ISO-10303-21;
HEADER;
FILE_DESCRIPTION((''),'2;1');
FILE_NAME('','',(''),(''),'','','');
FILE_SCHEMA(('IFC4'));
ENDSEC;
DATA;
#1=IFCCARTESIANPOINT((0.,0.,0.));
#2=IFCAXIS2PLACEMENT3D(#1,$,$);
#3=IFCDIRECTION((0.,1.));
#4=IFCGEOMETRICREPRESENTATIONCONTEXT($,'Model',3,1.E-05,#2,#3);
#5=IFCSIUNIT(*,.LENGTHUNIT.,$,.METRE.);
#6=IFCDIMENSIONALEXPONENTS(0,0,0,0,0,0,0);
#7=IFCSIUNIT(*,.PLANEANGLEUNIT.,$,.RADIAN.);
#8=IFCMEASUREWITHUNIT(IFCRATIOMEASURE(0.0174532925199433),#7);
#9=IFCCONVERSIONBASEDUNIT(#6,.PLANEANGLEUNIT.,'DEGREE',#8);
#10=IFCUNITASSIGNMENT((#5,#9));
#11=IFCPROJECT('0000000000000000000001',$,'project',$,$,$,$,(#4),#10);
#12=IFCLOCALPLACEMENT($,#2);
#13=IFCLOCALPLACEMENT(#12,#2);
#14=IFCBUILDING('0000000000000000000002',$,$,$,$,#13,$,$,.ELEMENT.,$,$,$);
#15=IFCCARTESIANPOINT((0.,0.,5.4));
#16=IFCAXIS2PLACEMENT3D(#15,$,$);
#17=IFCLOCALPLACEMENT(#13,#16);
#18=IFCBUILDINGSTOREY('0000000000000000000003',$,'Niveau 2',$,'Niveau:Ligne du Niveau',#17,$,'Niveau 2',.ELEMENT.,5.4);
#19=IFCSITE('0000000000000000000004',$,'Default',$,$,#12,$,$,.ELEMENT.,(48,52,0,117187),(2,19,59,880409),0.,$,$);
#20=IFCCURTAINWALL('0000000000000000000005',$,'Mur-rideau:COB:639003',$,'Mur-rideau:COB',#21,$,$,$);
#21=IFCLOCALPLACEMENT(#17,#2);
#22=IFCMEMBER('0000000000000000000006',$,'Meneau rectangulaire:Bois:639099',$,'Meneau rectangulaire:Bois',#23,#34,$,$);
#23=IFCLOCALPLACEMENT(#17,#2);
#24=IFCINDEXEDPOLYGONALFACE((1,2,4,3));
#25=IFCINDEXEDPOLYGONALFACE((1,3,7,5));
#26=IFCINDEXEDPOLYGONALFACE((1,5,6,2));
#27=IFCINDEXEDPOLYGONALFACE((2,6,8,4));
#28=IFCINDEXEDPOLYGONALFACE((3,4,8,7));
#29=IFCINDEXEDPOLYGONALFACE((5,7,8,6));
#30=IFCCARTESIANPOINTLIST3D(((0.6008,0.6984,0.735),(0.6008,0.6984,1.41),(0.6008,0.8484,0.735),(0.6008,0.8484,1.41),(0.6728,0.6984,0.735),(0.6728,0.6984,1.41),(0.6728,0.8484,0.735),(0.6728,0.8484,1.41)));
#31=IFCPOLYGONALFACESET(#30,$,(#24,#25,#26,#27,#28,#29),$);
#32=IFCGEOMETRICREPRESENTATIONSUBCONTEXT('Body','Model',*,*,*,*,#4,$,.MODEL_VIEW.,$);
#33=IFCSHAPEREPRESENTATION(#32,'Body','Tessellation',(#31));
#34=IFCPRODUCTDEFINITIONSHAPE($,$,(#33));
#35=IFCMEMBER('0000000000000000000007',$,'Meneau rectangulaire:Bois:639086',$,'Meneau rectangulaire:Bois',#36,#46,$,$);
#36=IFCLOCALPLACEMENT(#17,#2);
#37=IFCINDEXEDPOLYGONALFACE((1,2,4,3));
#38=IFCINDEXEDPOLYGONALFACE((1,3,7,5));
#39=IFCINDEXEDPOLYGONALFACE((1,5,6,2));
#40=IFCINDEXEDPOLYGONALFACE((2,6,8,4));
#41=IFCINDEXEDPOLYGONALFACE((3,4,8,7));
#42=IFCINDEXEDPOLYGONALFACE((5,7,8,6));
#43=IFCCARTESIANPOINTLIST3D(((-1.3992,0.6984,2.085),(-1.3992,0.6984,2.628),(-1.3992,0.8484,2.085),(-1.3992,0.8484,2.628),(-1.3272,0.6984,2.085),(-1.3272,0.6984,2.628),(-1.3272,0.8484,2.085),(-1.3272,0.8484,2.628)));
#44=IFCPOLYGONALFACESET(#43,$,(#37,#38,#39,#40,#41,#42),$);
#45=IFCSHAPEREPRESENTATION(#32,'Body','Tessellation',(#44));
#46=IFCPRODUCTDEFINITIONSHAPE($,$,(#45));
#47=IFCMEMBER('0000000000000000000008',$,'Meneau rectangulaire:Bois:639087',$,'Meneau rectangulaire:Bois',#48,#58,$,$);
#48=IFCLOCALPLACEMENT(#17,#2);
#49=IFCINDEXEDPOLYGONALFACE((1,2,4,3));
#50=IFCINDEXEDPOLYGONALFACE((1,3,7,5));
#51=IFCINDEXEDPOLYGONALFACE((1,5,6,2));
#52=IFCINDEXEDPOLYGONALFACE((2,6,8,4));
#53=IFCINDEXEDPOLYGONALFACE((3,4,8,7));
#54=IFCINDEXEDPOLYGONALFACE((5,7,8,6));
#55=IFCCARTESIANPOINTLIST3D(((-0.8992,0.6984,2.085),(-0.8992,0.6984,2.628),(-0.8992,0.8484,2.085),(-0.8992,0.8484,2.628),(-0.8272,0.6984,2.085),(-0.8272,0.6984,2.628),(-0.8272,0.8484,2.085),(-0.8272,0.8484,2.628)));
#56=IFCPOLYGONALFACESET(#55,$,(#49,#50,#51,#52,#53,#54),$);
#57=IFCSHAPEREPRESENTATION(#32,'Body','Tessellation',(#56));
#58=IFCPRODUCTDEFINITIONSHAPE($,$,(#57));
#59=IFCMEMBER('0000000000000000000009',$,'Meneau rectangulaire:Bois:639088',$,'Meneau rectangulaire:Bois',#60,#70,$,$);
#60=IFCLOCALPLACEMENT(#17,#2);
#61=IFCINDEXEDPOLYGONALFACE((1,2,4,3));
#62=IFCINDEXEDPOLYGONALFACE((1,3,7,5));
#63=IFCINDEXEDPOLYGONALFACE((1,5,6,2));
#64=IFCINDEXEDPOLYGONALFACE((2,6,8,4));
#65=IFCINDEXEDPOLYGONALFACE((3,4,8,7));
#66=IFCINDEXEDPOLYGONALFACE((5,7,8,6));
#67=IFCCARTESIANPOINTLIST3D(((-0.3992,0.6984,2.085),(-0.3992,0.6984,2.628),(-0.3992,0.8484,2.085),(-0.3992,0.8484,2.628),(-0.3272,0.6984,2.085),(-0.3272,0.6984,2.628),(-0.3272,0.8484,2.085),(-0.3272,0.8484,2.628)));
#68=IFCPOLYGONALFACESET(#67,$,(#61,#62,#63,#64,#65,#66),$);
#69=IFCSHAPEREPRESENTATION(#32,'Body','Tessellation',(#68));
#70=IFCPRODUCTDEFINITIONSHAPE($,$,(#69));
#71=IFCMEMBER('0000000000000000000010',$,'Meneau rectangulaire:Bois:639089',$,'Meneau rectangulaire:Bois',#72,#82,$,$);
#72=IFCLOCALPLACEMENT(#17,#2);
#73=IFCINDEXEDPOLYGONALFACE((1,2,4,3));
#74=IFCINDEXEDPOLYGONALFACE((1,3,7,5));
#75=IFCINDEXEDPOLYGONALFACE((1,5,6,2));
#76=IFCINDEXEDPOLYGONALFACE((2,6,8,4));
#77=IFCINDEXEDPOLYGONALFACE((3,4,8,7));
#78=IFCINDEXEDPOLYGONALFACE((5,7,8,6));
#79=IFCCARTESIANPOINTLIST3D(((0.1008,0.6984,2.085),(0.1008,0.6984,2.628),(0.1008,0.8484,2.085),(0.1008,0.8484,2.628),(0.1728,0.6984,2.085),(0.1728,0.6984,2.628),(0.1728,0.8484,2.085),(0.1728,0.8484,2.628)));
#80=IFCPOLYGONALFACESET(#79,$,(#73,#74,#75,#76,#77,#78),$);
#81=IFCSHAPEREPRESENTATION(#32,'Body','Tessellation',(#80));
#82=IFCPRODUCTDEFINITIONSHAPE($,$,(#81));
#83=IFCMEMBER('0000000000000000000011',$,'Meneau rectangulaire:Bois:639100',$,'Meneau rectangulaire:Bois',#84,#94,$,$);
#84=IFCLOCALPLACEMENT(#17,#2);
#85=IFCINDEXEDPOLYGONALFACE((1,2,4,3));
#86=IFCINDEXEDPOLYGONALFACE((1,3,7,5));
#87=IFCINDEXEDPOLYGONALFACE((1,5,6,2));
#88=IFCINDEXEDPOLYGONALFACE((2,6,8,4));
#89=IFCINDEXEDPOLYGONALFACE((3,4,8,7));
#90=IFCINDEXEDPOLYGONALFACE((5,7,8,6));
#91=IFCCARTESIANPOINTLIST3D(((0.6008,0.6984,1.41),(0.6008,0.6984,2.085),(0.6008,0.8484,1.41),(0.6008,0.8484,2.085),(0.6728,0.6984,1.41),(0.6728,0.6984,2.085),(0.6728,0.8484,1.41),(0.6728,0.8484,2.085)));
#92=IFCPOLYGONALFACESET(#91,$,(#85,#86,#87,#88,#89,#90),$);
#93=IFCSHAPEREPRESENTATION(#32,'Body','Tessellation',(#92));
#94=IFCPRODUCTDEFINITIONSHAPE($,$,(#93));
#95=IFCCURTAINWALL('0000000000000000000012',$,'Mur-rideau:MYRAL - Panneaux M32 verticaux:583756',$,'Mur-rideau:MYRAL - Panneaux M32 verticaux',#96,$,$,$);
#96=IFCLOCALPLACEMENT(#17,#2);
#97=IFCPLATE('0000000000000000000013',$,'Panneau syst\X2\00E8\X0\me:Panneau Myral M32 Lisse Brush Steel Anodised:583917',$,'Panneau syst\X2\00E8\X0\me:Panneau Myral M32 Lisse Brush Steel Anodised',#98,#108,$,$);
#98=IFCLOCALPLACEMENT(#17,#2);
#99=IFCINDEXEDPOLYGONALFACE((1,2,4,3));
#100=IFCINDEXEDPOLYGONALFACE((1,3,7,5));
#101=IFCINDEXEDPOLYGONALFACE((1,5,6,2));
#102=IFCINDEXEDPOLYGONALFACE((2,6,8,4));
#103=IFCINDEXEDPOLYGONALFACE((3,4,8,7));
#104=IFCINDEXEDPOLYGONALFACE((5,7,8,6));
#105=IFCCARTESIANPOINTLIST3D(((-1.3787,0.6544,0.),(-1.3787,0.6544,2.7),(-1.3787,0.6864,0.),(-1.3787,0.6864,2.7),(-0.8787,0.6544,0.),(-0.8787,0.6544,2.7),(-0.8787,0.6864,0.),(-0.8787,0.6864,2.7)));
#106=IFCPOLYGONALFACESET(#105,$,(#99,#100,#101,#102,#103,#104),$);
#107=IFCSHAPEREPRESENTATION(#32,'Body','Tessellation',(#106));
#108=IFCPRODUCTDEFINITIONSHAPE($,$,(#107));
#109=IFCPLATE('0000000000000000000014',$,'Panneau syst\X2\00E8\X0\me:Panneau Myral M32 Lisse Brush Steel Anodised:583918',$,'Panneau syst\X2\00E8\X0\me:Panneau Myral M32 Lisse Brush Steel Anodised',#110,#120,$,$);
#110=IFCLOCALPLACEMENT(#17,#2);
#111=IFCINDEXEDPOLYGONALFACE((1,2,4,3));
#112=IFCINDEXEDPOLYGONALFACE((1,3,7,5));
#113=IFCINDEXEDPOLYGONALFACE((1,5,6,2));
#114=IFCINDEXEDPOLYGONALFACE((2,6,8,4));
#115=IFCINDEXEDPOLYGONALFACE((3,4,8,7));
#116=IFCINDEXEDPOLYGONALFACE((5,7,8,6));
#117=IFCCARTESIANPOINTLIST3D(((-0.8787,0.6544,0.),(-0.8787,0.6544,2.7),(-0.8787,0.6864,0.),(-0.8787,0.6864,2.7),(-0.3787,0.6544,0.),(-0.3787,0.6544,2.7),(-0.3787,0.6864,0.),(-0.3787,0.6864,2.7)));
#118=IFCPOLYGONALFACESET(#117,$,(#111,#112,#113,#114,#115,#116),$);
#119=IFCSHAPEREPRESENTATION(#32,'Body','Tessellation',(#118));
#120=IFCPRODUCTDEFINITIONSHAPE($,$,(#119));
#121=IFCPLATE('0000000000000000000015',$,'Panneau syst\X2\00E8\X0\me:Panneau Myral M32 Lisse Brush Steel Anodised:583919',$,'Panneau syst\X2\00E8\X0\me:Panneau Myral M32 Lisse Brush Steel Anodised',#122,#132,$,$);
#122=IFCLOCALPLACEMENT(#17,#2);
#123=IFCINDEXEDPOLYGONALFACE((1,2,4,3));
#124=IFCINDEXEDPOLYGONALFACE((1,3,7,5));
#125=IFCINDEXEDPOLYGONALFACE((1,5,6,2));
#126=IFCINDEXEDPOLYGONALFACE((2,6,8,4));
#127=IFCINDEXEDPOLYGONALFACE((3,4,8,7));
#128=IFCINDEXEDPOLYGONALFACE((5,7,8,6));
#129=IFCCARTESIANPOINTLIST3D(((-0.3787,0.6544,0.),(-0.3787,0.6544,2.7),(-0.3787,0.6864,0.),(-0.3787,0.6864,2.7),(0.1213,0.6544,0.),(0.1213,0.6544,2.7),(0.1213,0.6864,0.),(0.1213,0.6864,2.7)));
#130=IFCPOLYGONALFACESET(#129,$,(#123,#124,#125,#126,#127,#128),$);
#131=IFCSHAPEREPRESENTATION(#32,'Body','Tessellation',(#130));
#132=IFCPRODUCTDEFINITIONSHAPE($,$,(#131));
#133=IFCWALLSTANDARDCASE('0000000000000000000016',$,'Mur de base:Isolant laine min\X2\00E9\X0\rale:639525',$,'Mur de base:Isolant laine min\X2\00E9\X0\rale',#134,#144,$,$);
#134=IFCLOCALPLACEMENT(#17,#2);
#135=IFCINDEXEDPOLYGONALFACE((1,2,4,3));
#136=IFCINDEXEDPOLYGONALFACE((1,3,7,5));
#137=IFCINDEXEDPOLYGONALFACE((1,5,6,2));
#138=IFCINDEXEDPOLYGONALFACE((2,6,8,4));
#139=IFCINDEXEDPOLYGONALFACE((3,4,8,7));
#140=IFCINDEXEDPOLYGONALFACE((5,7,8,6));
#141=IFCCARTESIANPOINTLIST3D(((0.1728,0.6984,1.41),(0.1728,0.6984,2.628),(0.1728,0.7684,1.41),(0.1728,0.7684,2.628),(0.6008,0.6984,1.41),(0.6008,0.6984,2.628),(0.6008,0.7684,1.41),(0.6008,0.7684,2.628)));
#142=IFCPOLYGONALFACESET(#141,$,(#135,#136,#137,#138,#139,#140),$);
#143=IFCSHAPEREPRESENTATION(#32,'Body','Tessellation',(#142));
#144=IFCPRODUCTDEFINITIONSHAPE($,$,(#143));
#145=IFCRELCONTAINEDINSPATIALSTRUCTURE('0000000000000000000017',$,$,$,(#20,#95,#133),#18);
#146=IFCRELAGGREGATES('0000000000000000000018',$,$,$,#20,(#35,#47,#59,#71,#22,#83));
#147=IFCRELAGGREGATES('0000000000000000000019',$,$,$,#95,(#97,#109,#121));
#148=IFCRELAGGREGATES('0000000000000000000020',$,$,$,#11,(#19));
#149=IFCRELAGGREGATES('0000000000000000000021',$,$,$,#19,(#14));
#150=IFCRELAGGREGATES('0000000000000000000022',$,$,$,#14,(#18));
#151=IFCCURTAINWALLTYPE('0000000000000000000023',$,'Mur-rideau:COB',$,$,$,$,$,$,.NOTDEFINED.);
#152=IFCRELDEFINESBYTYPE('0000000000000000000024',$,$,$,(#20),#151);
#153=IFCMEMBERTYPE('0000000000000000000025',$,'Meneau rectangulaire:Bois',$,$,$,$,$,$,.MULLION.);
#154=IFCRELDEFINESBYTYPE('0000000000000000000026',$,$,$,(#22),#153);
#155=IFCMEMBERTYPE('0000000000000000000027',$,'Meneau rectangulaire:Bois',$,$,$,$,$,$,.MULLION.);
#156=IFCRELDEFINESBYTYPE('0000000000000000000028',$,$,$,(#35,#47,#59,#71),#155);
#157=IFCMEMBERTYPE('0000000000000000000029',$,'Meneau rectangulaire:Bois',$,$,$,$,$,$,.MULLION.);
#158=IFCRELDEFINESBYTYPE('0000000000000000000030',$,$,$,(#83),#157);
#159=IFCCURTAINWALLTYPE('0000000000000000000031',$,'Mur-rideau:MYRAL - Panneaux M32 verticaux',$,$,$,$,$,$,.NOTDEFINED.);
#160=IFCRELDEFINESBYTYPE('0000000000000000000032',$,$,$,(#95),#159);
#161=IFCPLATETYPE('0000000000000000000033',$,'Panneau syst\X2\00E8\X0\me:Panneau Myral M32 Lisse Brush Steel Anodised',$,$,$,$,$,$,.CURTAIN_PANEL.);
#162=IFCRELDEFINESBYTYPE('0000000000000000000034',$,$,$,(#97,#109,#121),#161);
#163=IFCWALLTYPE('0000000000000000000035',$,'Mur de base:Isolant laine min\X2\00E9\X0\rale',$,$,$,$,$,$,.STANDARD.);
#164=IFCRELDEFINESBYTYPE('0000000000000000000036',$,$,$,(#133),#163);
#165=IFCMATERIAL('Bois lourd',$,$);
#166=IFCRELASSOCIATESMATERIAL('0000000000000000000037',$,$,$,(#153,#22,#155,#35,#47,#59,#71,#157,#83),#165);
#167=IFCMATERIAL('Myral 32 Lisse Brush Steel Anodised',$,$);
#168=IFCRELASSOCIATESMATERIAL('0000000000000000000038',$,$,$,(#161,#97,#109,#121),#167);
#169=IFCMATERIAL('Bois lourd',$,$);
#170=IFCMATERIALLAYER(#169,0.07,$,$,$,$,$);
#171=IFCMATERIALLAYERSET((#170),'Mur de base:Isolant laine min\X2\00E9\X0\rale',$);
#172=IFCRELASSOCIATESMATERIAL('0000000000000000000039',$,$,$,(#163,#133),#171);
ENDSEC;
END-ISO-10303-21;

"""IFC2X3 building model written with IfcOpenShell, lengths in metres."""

from ifc_helpers import new_model, entity, si_unit, converted_unit, direction, frame, frame_2d, origin, origin_2d_with_axis, place, context, subcontext, project, spatial, rectangle, extrude, source, transform, mapped, material, layer, layer_set, layer_usage, type_object, type_shapes, element, aggregate, save


model = new_model("IFC2X3")

# Units and contexts
model_context = context("Model", 3, precision=1e-05, world=origin(), true_north=direction((0.0, 1.0)))
body_context = subcontext(model_context, "Body", "Model", "MODEL_VIEW")
ifc_project = project(units=[si_unit("LENGTHUNIT", "METRE"), converted_unit("PLANEANGLEUNIT", "DEGREE", entity("IfcRatioMeasure", 0.0174532925199433), si_unit("PLANEANGLEUNIT", "RADIAN"), dimensions=[0, 0, 0, 0, 0, 0, 0])], contexts=[model_context])

# Site, building, storey
site_placement = place(None, origin())
site = spatial("IfcSite", under=ifc_project, at=site_placement, Name="Default", CompositionType="ELEMENT", RefLatitude=(48, 52, 0, 117187), RefLongitude=(2, 19, 59, 880409), RefElevation=0.0)
building_placement = place(site_placement, origin())
building = spatial("IfcBuilding", under=site, at=building_placement, CompositionType="ELEMENT")
storey_placement = place(building_placement, frame((0.0, 0.0, 5.4)))
storey = spatial("IfcBuildingStorey", under=building, at=storey_placement, Name="Niveau 2", ObjectType="Niveau:Ligne du Niveau", LongName="Niveau 2", CompositionType="ELEMENT", Elevation=5.4)

# Curtain wall, members
curtain_wall_type_1 = type_object("IfcCurtainWallType", Name="Mur-rideau:COB", PredefinedType="NOTDEFINED")
curtain_wall_1_placement = place(storey_placement, frame((0.0, 0.0, -5.4)))
curtain_wall_1 = element("IfcCurtainWall", 1, at=curtain_wall_1_placement, inside=storey, type_object=curtain_wall_type_1, Name="Mur-rideau:COB:639003", ObjectType="Mur-rideau:COB")
ifc_material_1 = material(Name="Bois lourd")
member_type_1 = type_object("IfcMemberType", Name="Meneau rectangulaire:Bois", PredefinedType="MULLION", material=ifc_material_1)
shared_shape_1 = source(origin(), body_context, "Body", "SweptSolid", [
    extrude(rectangle(XDim=0.15, YDim=0.072, at=origin_2d_with_axis()), frame((-0.024, 0.0, -0.675), z_axis=(0.0, 0.0, 1.0), x_axis=(0.0, -1.0, 0.0)), (0.0, 0.0, 1.0), 0.675),
])
type_shapes(member_type_1, [shared_shape_1])
member_1_placement = place(storey_placement, frame((0.6608, 0.7734, 0.735), z_axis=(0.0, 0.0, -1.0), x_axis=(1.0, 0.0, 0.0)))
member_1 = element("IfcMember", 2, at=member_1_placement, type_object=member_type_1, material=ifc_material_1, Name="Meneau rectangulaire:Bois:639099", ObjectType="Meneau rectangulaire:Bois", context=body_context, shape_type="MappedRepresentation", body=[
    mapped(shared_shape_1, transform((0.0, 0.0, 0.0), scale=1.0)),
])
member_type_2 = type_object("IfcMemberType", Name="Meneau rectangulaire:Bois", PredefinedType="MULLION", material=ifc_material_1)
shared_shape_2 = source(origin(), body_context, "Body", "SweptSolid", [
    extrude(rectangle(XDim=0.15, YDim=0.072, at=origin_2d_with_axis()), frame((-0.024, 0.0, -0.543), z_axis=(0.0, 0.0, 1.0), x_axis=(0.0, -1.0, 0.0)), (0.0, 0.0, 1.0), 0.543),
])
type_shapes(member_type_2, [shared_shape_2])
member_2_placement = place(storey_placement, frame((-1.3392, 0.7734, 2.085), z_axis=(0.0, 0.0, -1.0), x_axis=(1.0, 0.0, 0.0)))
member_2 = element("IfcMember", 3, at=member_2_placement, type_object=member_type_2, material=ifc_material_1, Name="Meneau rectangulaire:Bois:639086", ObjectType="Meneau rectangulaire:Bois", context=body_context, shape_type="MappedRepresentation", body=[
    mapped(shared_shape_2, transform((0.0, 0.0, 0.0), scale=1.0)),
])
member_3_placement = place(storey_placement, frame((-0.8392, 0.7734, 2.085), z_axis=(0.0, 0.0, -1.0), x_axis=(1.0, 0.0, 0.0)))
member_3 = element("IfcMember", 4, at=member_3_placement, type_object=member_type_2, material=ifc_material_1, Name="Meneau rectangulaire:Bois:639087", ObjectType="Meneau rectangulaire:Bois", context=body_context, shape_type="MappedRepresentation", body=[
    mapped(shared_shape_2, transform((0.0, 0.0, 0.0), scale=1.0)),
])
member_4_placement = place(storey_placement, frame((-0.3392, 0.7734, 2.085), z_axis=(0.0, 0.0, -1.0), x_axis=(1.0, 0.0, 0.0)))
member_4 = element("IfcMember", 5, at=member_4_placement, type_object=member_type_2, material=ifc_material_1, Name="Meneau rectangulaire:Bois:639088", ObjectType="Meneau rectangulaire:Bois", context=body_context, shape_type="MappedRepresentation", body=[
    mapped(shared_shape_2, transform((0.0, 0.0, 0.0), scale=1.0)),
])
member_5_placement = place(storey_placement, frame((0.1608, 0.7734, 2.085), z_axis=(0.0, 0.0, -1.0), x_axis=(1.0, 0.0, 0.0)))
member_5 = element("IfcMember", 6, at=member_5_placement, type_object=member_type_2, material=ifc_material_1, Name="Meneau rectangulaire:Bois:639089", ObjectType="Meneau rectangulaire:Bois", context=body_context, shape_type="MappedRepresentation", body=[
    mapped(shared_shape_2, transform((0.0, 0.0, 0.0), scale=1.0)),
])
member_type_3 = type_object("IfcMemberType", Name="Meneau rectangulaire:Bois", PredefinedType="MULLION", material=ifc_material_1)
shared_shape_3 = source(origin(), body_context, "Body", "SweptSolid", [
    extrude(rectangle(XDim=0.15, YDim=0.072, at=origin_2d_with_axis()), frame((-0.024, 0.0, -0.675), z_axis=(0.0, 0.0, 1.0), x_axis=(0.0, -1.0, 0.0)), (0.0, 0.0, 1.0), 0.675),
])
type_shapes(member_type_3, [shared_shape_3])
member_6_placement = place(storey_placement, frame((0.6608, 0.7734, 1.41), z_axis=(0.0, 0.0, -1.0), x_axis=(1.0, 0.0, 0.0)))
member_6 = element("IfcMember", 7, at=member_6_placement, type_object=member_type_3, material=ifc_material_1, Name="Meneau rectangulaire:Bois:639100", ObjectType="Meneau rectangulaire:Bois", context=body_context, shape_type="MappedRepresentation", body=[
    mapped(shared_shape_3, transform((0.0, 0.0, 0.0), scale=1.0)),
])
aggregate(curtain_wall_1, [member_2, member_3, member_4, member_5, member_1, member_6])

# Curtain wall, plates
curtain_wall_type_2 = type_object("IfcCurtainWallType", Name="Mur-rideau:MYRAL - Panneaux M32 verticaux", PredefinedType="NOTDEFINED")
curtain_wall_2_placement = place(storey_placement, frame((0.0, 0.0, -5.4)))
curtain_wall_2 = element("IfcCurtainWall", 8, at=curtain_wall_2_placement, inside=storey, type_object=curtain_wall_type_2, Name="Mur-rideau:MYRAL - Panneaux M32 verticaux:583756", ObjectType="Mur-rideau:MYRAL - Panneaux M32 verticaux")
ifc_material_2 = material(Name="Myral 32 Lisse Brush Steel Anodised")
plate_type = type_object("IfcPlateType", Name="Panneau système:Panneau Myral M32 Lisse Brush Steel Anodised", PredefinedType="CURTAIN_PANEL", material=ifc_material_2)
shared_shape_4 = source(origin(), body_context, "Body", "SweptSolid", [
    extrude(rectangle(XDim=0.032, YDim=0.5, at=origin_2d_with_axis()), frame((0.0, -0.016, 0.0), z_axis=(0.0, 0.0, 1.0), x_axis=(0.0, 1.0, 0.0)), (0.0, 0.0, 1.0), 2.7),
])
type_shapes(plate_type, [shared_shape_4])
plate_1_placement = place(curtain_wall_2_placement, frame((-1.1287, 0.6864, 5.4)))
plate_1 = element("IfcPlate", 9, at=plate_1_placement, type_object=plate_type, material=ifc_material_2, Name="Panneau système:Panneau Myral M32 Lisse Brush Steel Anodised:583917", ObjectType="Panneau système:Panneau Myral M32 Lisse Brush Steel Anodised", context=body_context, shape_type="MappedRepresentation", body=[
    mapped(shared_shape_4, transform((0.0, 0.0, 0.0), scale=1.0)),
])
plate_2_placement = place(curtain_wall_2_placement, frame((-0.6287, 0.6864, 5.4)))
plate_2 = element("IfcPlate", 10, at=plate_2_placement, type_object=plate_type, material=ifc_material_2, Name="Panneau système:Panneau Myral M32 Lisse Brush Steel Anodised:583918", ObjectType="Panneau système:Panneau Myral M32 Lisse Brush Steel Anodised", context=body_context, shape_type="MappedRepresentation", body=[
    mapped(shared_shape_4, transform((0.0, 0.0, 0.0), scale=1.0)),
])
plate_3_placement = place(curtain_wall_2_placement, frame((-0.1287, 0.6864, 5.4)))
plate_3 = element("IfcPlate", 11, at=plate_3_placement, type_object=plate_type, material=ifc_material_2, Name="Panneau système:Panneau Myral M32 Lisse Brush Steel Anodised:583919", ObjectType="Panneau système:Panneau Myral M32 Lisse Brush Steel Anodised", context=body_context, shape_type="MappedRepresentation", body=[
    mapped(shared_shape_4, transform((0.0, 0.0, 0.0), scale=1.0)),
])
aggregate(curtain_wall_2, [plate_1, plate_2, plate_3])

# Wall
ifc_material_3 = material(Name="Bois lourd")
ifc_layer = layer(ifc_material_3, 0.07)
ifc_layer_set = layer_set([ifc_layer], Name="Mur de base:Isolant laine minérale")
ifc_layer_usage = layer_usage(ifc_layer_set, "AXIS2", "NEGATIVE", 0.035)
wall_type = type_object("IfcWallType", Name="Mur de base:Isolant laine minérale", PredefinedType="STANDARD", material=ifc_layer_set)
wall_placement = place(storey_placement, frame((0.1728, 0.7334, 1.41)))
element("IfcWallStandardCase", 12, at=wall_placement, inside=storey, type_object=wall_type, material=ifc_layer_usage, Name="Mur de base:Isolant laine minérale:639525", ObjectType="Mur de base:Isolant laine minérale", context=body_context, shape_type="SweptSolid", body=[
    extrude(rectangle(XDim=0.428, YDim=0.07, at=frame_2d((0.214, 0.0), x_axis=(-1.0, 0.0))), origin(), (0.0, 0.0, 1.0), 1.218),
])

save(model, "model.ifc")
